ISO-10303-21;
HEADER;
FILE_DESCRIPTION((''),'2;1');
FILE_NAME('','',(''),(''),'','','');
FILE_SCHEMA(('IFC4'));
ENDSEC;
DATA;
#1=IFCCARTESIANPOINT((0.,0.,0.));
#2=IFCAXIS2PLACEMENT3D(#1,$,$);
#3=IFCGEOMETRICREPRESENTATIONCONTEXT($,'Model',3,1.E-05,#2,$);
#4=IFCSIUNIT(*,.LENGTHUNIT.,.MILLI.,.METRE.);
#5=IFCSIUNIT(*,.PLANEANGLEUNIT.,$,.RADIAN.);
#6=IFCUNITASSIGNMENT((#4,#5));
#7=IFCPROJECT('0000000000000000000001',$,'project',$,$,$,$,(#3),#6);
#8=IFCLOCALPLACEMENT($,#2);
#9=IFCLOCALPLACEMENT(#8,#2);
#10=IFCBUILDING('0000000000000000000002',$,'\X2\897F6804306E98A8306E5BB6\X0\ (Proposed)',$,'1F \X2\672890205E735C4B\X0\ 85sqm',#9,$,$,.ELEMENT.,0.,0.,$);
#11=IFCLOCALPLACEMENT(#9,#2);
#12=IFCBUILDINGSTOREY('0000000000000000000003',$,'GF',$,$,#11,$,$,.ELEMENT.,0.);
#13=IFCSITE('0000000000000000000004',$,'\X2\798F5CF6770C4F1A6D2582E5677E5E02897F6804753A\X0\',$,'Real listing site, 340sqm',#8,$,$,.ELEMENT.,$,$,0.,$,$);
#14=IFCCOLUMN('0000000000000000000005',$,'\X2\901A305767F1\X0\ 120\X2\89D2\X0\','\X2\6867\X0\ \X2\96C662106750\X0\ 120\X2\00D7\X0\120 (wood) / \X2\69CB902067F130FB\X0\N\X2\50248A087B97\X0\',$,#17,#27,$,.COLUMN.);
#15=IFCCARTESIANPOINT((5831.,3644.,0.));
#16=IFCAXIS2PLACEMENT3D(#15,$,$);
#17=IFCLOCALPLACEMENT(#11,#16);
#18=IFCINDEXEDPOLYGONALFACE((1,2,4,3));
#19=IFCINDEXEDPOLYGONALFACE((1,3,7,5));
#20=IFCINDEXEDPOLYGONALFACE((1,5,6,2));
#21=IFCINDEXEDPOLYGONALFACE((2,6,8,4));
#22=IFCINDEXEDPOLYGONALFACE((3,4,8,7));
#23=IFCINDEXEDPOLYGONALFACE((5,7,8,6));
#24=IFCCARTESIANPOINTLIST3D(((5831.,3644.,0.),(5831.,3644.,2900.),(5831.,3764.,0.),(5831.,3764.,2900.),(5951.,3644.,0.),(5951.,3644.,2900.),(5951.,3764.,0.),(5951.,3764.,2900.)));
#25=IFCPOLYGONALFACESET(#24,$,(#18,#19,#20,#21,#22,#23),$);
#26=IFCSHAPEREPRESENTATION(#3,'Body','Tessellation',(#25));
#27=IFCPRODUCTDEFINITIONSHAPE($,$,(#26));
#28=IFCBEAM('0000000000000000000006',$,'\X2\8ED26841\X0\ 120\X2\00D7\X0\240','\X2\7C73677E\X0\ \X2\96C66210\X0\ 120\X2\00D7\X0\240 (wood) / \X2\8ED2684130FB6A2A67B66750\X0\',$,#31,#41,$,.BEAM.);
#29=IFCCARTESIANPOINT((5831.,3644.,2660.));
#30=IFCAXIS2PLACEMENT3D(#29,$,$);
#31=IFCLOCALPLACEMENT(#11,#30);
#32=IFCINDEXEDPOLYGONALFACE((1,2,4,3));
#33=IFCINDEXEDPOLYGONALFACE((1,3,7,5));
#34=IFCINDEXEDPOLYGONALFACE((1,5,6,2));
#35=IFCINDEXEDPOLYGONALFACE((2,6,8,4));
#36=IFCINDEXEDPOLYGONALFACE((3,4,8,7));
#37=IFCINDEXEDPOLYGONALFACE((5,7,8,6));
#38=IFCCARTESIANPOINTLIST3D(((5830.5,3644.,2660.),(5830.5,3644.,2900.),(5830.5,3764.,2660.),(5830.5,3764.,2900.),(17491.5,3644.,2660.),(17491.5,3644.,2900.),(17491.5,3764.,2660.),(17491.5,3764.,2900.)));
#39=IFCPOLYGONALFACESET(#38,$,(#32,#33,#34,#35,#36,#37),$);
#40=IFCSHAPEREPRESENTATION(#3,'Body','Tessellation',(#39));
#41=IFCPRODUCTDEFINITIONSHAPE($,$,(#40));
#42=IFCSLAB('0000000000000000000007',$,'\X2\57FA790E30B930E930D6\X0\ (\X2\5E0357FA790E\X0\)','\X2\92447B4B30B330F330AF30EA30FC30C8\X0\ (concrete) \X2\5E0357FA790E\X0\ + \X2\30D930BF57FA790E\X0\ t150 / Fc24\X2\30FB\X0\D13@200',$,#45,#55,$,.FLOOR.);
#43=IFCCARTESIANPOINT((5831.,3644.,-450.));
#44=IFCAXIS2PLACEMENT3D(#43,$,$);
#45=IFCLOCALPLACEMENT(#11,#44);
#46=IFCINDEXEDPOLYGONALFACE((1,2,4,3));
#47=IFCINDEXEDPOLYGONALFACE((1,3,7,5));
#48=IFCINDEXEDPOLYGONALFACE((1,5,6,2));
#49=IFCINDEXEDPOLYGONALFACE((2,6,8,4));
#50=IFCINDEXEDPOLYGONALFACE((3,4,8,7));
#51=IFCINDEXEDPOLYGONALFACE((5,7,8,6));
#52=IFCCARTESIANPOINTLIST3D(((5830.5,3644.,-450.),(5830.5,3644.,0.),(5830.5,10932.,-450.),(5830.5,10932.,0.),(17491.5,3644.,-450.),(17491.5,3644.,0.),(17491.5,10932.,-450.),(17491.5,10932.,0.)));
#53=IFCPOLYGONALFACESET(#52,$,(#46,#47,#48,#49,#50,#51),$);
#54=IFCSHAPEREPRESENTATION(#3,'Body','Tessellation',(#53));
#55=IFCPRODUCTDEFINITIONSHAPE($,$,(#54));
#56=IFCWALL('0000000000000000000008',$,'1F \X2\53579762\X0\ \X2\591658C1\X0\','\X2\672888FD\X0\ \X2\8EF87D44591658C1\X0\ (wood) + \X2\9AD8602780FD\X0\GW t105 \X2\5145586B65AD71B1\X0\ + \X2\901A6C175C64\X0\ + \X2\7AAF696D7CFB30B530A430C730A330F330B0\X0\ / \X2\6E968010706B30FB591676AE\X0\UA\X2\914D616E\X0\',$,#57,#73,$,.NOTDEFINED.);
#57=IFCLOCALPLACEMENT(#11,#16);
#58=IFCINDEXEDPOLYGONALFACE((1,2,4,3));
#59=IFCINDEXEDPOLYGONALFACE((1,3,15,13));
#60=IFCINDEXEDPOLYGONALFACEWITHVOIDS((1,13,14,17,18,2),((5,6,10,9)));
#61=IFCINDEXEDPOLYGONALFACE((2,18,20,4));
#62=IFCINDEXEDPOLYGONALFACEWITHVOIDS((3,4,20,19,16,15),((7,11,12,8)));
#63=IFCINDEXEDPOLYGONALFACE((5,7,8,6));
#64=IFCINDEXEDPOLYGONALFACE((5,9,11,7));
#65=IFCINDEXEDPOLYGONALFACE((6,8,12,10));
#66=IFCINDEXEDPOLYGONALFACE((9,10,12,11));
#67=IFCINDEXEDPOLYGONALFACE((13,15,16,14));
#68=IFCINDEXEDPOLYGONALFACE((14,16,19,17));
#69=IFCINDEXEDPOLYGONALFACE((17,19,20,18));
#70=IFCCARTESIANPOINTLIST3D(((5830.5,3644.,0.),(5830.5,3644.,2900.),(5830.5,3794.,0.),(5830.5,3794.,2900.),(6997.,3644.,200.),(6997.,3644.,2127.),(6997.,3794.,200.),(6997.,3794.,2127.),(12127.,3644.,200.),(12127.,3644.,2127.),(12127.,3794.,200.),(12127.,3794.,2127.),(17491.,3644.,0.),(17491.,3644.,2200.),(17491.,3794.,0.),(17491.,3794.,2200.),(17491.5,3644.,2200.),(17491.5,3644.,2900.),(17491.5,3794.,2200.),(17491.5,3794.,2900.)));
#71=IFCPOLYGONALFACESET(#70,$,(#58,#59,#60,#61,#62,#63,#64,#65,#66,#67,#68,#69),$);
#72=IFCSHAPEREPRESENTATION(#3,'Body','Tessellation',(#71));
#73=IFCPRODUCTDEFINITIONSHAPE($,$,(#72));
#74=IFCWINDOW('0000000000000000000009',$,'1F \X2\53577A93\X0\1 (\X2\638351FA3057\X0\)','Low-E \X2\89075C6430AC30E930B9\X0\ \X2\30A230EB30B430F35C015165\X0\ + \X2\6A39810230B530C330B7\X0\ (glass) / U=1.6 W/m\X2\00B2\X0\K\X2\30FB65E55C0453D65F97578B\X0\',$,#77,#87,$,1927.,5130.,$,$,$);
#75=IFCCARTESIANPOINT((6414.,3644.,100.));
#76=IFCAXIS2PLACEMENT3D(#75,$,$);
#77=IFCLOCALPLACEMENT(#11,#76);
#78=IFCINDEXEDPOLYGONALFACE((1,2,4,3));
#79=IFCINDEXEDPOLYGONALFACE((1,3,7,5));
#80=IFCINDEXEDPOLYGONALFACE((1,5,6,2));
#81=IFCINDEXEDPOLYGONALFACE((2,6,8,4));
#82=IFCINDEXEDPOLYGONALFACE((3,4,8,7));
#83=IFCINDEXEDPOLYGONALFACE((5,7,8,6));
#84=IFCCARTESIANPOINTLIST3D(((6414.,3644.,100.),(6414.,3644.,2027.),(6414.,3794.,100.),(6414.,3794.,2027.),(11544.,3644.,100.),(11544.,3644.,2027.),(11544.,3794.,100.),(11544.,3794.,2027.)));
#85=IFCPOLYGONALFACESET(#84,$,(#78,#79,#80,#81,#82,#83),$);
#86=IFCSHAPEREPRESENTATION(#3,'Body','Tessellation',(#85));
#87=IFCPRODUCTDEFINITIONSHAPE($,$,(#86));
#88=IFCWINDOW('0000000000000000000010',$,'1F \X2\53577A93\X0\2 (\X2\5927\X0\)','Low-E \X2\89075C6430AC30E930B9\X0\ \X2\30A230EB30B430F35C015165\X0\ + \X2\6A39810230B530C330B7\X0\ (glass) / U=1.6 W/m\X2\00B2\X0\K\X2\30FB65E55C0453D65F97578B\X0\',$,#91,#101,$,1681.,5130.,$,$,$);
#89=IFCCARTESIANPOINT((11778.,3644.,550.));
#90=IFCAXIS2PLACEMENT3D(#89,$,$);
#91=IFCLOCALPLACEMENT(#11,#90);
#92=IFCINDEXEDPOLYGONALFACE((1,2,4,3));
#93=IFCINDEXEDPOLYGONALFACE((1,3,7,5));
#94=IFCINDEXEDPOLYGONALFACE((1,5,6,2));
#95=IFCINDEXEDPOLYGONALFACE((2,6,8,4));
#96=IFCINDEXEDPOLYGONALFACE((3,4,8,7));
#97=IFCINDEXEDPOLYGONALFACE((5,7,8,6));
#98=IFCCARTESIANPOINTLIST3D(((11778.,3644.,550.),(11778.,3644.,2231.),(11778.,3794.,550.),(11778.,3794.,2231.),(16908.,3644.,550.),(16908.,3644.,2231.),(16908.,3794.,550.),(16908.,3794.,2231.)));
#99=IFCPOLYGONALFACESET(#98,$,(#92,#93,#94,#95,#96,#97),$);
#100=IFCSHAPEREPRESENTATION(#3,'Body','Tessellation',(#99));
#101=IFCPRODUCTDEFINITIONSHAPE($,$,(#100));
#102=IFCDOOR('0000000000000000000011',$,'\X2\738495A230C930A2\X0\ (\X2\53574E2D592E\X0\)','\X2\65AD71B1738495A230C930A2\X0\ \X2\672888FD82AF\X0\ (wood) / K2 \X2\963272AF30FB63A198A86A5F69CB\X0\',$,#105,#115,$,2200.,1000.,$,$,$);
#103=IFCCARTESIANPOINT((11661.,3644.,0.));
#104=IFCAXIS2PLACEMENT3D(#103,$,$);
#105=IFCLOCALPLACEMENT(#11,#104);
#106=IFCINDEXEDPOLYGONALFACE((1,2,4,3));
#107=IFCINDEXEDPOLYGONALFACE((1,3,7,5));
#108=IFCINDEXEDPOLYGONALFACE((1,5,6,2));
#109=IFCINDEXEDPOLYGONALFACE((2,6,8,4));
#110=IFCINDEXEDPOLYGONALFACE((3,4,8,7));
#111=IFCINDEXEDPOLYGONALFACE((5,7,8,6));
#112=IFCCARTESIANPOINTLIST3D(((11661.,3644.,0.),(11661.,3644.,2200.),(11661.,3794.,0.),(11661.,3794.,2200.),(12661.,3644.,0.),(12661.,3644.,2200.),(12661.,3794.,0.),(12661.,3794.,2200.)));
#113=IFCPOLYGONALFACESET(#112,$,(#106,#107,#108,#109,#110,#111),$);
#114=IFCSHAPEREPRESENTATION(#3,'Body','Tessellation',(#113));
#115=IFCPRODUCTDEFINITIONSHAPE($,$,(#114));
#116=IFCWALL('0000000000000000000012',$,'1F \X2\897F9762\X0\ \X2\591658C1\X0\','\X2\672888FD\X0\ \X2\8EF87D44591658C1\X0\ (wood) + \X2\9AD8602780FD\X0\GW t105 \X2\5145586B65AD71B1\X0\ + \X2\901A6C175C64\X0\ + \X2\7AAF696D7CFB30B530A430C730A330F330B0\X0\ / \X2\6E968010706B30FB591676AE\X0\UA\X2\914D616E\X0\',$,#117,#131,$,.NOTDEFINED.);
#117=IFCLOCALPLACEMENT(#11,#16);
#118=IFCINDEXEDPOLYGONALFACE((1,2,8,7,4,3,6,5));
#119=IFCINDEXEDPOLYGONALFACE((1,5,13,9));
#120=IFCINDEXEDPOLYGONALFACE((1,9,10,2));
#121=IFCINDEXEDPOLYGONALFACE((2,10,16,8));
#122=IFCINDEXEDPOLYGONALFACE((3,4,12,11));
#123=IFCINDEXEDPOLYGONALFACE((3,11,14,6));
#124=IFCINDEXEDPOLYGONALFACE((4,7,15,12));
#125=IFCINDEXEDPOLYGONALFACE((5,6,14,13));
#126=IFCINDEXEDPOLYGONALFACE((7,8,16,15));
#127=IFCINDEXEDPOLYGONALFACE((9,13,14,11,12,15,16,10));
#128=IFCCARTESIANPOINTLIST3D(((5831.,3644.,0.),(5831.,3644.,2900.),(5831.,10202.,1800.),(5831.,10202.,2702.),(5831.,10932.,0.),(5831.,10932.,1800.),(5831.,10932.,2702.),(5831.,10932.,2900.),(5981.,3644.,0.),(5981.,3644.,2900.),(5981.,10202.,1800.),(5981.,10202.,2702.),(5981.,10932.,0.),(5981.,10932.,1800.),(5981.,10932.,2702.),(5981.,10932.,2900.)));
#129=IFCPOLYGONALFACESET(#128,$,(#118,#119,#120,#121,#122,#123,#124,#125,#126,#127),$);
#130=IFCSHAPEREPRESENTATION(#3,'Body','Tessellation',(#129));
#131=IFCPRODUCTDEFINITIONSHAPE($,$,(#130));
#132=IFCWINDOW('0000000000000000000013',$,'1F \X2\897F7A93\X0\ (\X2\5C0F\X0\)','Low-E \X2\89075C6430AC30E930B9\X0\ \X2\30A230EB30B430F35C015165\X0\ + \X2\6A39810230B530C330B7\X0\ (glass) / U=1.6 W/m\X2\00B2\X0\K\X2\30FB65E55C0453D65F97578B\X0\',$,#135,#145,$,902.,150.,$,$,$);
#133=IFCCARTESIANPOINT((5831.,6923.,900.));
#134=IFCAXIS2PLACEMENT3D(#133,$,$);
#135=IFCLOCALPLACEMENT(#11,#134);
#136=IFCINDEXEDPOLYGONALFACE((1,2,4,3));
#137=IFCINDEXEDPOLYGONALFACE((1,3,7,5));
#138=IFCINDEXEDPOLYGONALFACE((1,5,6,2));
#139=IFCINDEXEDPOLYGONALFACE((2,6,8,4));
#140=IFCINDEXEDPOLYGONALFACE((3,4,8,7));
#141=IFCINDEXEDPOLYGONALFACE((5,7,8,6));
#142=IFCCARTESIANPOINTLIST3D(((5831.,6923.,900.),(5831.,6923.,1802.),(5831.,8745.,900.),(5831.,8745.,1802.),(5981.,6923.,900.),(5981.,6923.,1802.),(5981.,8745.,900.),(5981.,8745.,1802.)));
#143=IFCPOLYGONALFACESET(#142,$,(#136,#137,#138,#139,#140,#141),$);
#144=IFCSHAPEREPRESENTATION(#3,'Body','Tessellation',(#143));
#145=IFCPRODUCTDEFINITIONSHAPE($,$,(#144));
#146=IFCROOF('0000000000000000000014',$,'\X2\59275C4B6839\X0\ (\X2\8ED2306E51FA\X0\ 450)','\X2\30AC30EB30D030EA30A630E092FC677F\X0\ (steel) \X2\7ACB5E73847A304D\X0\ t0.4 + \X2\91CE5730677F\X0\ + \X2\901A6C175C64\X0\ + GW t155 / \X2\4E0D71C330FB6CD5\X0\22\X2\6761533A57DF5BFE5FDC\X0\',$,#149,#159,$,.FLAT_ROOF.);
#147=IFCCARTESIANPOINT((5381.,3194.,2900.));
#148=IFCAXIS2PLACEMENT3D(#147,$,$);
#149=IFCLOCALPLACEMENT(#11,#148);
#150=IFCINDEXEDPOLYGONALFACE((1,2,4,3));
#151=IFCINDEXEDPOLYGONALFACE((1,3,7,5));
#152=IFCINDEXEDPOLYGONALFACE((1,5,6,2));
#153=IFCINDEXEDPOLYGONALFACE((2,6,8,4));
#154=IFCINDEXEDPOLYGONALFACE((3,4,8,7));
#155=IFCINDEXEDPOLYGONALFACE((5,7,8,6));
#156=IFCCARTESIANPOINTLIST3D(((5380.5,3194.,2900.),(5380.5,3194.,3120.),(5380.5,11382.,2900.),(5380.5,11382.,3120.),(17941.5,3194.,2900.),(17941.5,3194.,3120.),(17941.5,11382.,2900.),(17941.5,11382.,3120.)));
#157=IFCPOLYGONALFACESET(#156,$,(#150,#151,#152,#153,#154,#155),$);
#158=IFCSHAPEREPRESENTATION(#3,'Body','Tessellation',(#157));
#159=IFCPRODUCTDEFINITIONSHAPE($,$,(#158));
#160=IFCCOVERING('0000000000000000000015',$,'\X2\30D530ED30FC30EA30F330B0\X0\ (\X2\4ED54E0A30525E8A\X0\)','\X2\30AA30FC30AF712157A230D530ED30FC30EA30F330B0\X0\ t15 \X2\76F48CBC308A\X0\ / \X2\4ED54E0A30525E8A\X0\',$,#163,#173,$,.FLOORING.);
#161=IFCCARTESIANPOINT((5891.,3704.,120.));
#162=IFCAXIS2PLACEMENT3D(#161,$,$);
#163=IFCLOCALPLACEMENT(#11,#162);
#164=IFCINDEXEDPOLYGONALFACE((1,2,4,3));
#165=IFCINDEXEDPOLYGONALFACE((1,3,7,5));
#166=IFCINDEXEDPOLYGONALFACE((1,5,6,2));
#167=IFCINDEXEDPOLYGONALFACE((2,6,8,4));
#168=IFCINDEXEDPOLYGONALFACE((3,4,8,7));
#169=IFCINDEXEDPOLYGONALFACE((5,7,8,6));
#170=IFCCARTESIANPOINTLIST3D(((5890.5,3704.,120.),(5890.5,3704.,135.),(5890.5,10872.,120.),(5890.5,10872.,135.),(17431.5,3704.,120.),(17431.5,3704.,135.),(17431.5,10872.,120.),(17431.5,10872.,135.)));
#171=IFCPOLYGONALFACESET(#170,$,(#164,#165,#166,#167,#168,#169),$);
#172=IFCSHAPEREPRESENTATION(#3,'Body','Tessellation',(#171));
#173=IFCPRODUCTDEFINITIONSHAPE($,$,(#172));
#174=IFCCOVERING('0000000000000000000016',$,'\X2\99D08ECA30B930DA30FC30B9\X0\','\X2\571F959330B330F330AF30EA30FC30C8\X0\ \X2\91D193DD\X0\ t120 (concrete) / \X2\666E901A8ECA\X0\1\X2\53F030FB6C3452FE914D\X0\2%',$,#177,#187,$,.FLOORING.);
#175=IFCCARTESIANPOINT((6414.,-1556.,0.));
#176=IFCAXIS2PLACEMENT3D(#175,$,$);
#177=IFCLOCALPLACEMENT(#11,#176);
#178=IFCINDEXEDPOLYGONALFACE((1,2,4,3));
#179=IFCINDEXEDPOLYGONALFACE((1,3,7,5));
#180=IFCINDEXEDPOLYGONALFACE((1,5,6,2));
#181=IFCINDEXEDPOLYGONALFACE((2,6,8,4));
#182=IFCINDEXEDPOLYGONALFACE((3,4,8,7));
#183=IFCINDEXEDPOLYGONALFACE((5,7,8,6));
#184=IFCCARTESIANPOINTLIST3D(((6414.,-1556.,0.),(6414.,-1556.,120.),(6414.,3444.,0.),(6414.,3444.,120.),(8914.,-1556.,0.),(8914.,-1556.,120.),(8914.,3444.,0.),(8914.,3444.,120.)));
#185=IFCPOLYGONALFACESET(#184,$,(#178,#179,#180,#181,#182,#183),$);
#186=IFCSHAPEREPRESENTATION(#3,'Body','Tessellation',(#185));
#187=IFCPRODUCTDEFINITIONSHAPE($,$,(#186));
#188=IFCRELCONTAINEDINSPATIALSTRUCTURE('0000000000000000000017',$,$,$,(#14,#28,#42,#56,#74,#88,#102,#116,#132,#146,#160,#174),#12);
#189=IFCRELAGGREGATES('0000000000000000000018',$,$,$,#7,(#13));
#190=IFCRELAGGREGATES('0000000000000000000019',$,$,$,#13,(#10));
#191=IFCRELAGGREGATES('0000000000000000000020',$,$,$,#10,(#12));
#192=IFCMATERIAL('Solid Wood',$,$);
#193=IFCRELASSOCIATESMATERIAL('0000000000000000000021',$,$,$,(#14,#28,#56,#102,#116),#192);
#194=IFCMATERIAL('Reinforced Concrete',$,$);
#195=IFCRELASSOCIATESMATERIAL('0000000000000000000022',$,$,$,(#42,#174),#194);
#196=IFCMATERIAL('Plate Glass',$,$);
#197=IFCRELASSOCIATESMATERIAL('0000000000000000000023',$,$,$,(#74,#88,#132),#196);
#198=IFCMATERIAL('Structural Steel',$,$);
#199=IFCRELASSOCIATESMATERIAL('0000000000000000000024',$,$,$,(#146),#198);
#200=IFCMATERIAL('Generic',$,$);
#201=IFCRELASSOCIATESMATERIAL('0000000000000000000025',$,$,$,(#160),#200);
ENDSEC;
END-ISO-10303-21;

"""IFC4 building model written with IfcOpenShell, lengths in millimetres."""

from ifc_helpers import new_model, si_unit, frame, frame_2d, origin, place, context, project, spatial, rectangle, extrude, material, element, fill, save


model = new_model("IFC4")

# Units and contexts
model_context = context("Model", 3, precision=1e-05, world=origin())
ifc_project = project(units=[si_unit("LENGTHUNIT", "METRE", prefix="MILLI"), si_unit("PLANEANGLEUNIT", "RADIAN")], contexts=[model_context])

# Site, building, storey
site_placement = place(None, origin())
site = spatial("IfcSite", under=ifc_project, at=site_placement, Name="福島県会津若松市西栄町", ObjectType="Real listing site, 340sqm", CompositionType="ELEMENT", RefElevation=0.0)
building_placement = place(site_placement, origin())
building = spatial("IfcBuilding", under=site, at=building_placement, Name="西栄の風の家 (Proposed)", ObjectType="1F 木造平屋 85sqm", CompositionType="ELEMENT", ElevationOfRefHeight=0.0, ElevationOfTerrain=0.0)
storey_placement = place(building_placement, origin())
storey = spatial("IfcBuildingStorey", under=building, at=storey_placement, Name="GF", CompositionType="ELEMENT", Elevation=0.0)

# Column
ifc_material_1 = material(Name="Solid Wood")
column_1_placement = place(storey_placement, frame((5831.0, 3644.0, 0.0)))
element("IfcColumn", 1, at=column_1_placement, inside=storey, material=ifc_material_1, Name="通し柱 120角", Description="桧 集成材 120×120 (wood) / 構造柱・N値計算", PredefinedType="COLUMN", context=model_context, shape_type="SweptSolid", body=[
    extrude(rectangle(XDim=120.0, YDim=120.0, at=frame_2d((60.0, 60.0))), frame((5831.0, 3644.0, 0.0)), (0.0, 0.0, 1.0), 2900.0),
])

# Beam
beam_1_placement = place(storey_placement, frame((5831.0, 3644.0, 2660.0)))
element("IfcBeam", 2, at=beam_1_placement, inside=storey, material=ifc_material_1, Name="軒桁 120×240", Description="米松 集成 120×240 (wood) / 軒桁・横架材", PredefinedType="BEAM", context=model_context, shape_type="SweptSolid", body=[
    extrude(rectangle(XDim=11661.0, YDim=120.0, at=frame_2d((5830.0, 60.0))), frame((5831.0, 3644.0, 2660.0)), (0.0, 0.0, 1.0), 240.0),
])

# Slab
ifc_material_2 = material(Name="Reinforced Concrete")
slab_1_placement = place(storey_placement, frame((5831.0, 3644.0, -450.0)))
element("IfcSlab", 3, at=slab_1_placement, inside=storey, material=ifc_material_2, Name="基礎スラブ (布基礎)", Description="鉄筋コンクリート (concrete) 布基礎 + ベタ基礎 t150 / Fc24・D13@200", PredefinedType="FLOOR", context=model_context, shape_type="SweptSolid", body=[
    extrude(rectangle(XDim=11661.0, YDim=7288.0, at=frame_2d((5830.0, 3644.0))), frame((5831.0, 3644.0, -450.0)), (0.0, 0.0, 1.0), 450.0),
])

# Wall, openings, windows, door
wall_1_placement = place(storey_placement, frame((5831.0, 3644.0, 0.0)))
wall_1 = element("IfcWall", 4, at=wall_1_placement, inside=storey, material=ifc_material_1, Name="1F 南面 外壁", Description="木製 軸組外壁 (wood) + 高性能GW t105 充填断熱 + 通気層 + 窯業系サイディング / 準耐火・外皮UA配慮", PredefinedType="NOTDEFINED", context=model_context, shape_type="SweptSolid", body=[
    extrude(rectangle(XDim=11661.0, YDim=150.0, at=frame_2d((5830.0, 75.0))), frame((5831.0, 3644.0, 0.0)), (0.0, 0.0, 1.0), 2900.0),
])
opening_1_placement = place(storey_placement, frame((6414.0, 3644.0, 100.0)))
opening_1 = element("IfcOpeningElement", 5, at=opening_1_placement, cuts=wall_1, PredefinedType="NOTDEFINED", context=model_context, shape_type="SweptSolid", body=[
    extrude(rectangle(XDim=5130.0, YDim=150.0, at=frame_2d((2565.0, 75.0))), frame((6414.0, 3644.0, 100.0)), (0.0, 0.0, 1.0), 1927.0),
])
opening_2_placement = place(storey_placement, frame((11778.0, 3644.0, 550.0)))
opening_2 = element("IfcOpeningElement", 6, at=opening_2_placement, cuts=wall_1, PredefinedType="NOTDEFINED", context=model_context, shape_type="SweptSolid", body=[
    extrude(rectangle(XDim=5130.0, YDim=150.0, at=frame_2d((2565.0, 75.0))), frame((11778.0, 3644.0, 550.0)), (0.0, 0.0, 1.0), 1681.0),
])
opening_3_placement = place(storey_placement, frame((11661.0, 3644.0, 0.0)))
opening_3 = element("IfcOpeningElement", 7, at=opening_3_placement, cuts=wall_1, PredefinedType="NOTDEFINED", context=model_context, shape_type="SweptSolid", body=[
    extrude(rectangle(XDim=1000.0, YDim=150.0, at=frame_2d((500.0, 75.0))), frame((11661.0, 3644.0, 0.0)), (0.0, 0.0, 1.0), 2200.0),
])
ifc_material_3 = material(Name="Plate Glass")
window_1_placement = place(storey_placement, frame((6414.0, 3644.0, 100.0)))
window_1 = element("IfcWindow", 8, at=window_1_placement, inside=storey, material=ifc_material_3, Name="1F 南窓1 (掃出し)", Description="Low-E 複層ガラス アルゴン封入 + 樹脂サッシ (glass) / U=1.6 W/m²K・日射取得型", OverallHeight=1927.0, OverallWidth=5130.0, context=model_context, shape_type="SweptSolid", body=[
    extrude(rectangle(XDim=5130.0, YDim=150.0, at=frame_2d((2565.0, 75.0))), frame((6414.0, 3644.0, 100.0)), (0.0, 0.0, 1.0), 1927.0),
])
fill(opening_1, window_1)
window_2_placement = place(storey_placement, frame((11778.0, 3644.0, 550.0)))
window_2 = element("IfcWindow", 9, at=window_2_placement, inside=storey, material=ifc_material_3, Name="1F 南窓2 (大)", Description="Low-E 複層ガラス アルゴン封入 + 樹脂サッシ (glass) / U=1.6 W/m²K・日射取得型", OverallHeight=1681.0, OverallWidth=5130.0, context=model_context, shape_type="SweptSolid", body=[
    extrude(rectangle(XDim=5130.0, YDim=150.0, at=frame_2d((2565.0, 75.0))), frame((11778.0, 3644.0, 550.0)), (0.0, 0.0, 1.0), 1681.0),
])
fill(opening_2, window_2)
door_placement = place(storey_placement, frame((11661.0, 3644.0, 0.0)))
door = element("IfcDoor", 10, at=door_placement, inside=storey, material=ifc_material_1, Name="玄関ドア (南中央)", Description="断熱玄関ドア 木製芯 (wood) / K2 防犯・採風機構", OverallHeight=2200.0, OverallWidth=1000.0, context=model_context, shape_type="SweptSolid", body=[
    extrude(rectangle(XDim=1000.0, YDim=150.0, at=frame_2d((500.0, 75.0))), frame((11661.0, 3644.0, 0.0)), (0.0, 0.0, 1.0), 2200.0),
])
fill(opening_3, door)

# Wall, opening, window
wall_2_placement = place(storey_placement, frame((5831.0, 3644.0, 0.0)))
wall_2 = element("IfcWall", 11, at=wall_2_placement, inside=storey, material=ifc_material_1, Name="1F 西面 外壁", Description="木製 軸組外壁 (wood) + 高性能GW t105 充填断熱 + 通気層 + 窯業系サイディング / 準耐火・外皮UA配慮", PredefinedType="NOTDEFINED", context=model_context, shape_type="SweptSolid", body=[
    extrude(rectangle(XDim=150.0, YDim=7288.0, at=frame_2d((75.0, 3644.0))), frame((5831.0, 3644.0, 0.0)), (0.0, 0.0, 1.0), 2900.0),
])
opening_4_placement = place(storey_placement, frame((5831.0, 6923.0, 900.0)))
opening_4 = element("IfcOpeningElement", 12, at=opening_4_placement, cuts=wall_2, PredefinedType="NOTDEFINED", context=model_context, shape_type="SweptSolid", body=[
    extrude(rectangle(XDim=150.0, YDim=1822.0, at=frame_2d((75.0, 911.0))), frame((5831.0, 6923.0, 900.0)), (0.0, 0.0, 1.0), 902.0),
])
window_3_placement = place(storey_placement, frame((5831.0, 6923.0, 900.0)))
window_3 = element("IfcWindow", 13, at=window_3_placement, inside=storey, material=ifc_material_3, Name="1F 西窓 (小)", Description="Low-E 複層ガラス アルゴン封入 + 樹脂サッシ (glass) / U=1.6 W/m²K・日射取得型", OverallHeight=902.0, OverallWidth=150.0, context=model_context, shape_type="SweptSolid", body=[
    extrude(rectangle(XDim=150.0, YDim=1822.0, at=frame_2d((75.0, 911.0))), frame((5831.0, 6923.0, 900.0)), (0.0, 0.0, 1.0), 902.0),
])
fill(opening_4, window_3)

# Roof
ifc_material_4 = material(Name="Structural Steel")
roof_placement = place(storey_placement, frame((5381.0, 3194.0, 2900.0)))
element("IfcRoof", 14, at=roof_placement, inside=storey, material=ifc_material_4, Name="大屋根 (軒の出 450)", Description="ガルバリウム鋼板 (steel) 立平葺き t0.4 + 野地板 + 通気層 + GW t155 / 不燃・法22条区域対応", PredefinedType="FLAT_ROOF", context=model_context, shape_type="SweptSolid", body=[
    extrude(rectangle(XDim=12561.0, YDim=8188.0, at=frame_2d((6280.0, 4094.0))), frame((5381.0, 3194.0, 2900.0)), (0.0, 0.0, 1.0), 220.0),
])

# Coverings
ifc_material_5 = material(Name="Generic")
covering_1_placement = place(storey_placement, frame((5891.0, 3704.0, 120.0)))
element("IfcCovering", 15, at=covering_1_placement, inside=storey, material=ifc_material_5, Name="フローリング (仕上げ床)", Description="オーク無垢フローリング t15 直貼り / 仕上げ床", PredefinedType="FLOORING", context=model_context, shape_type="SweptSolid", body=[
    extrude(rectangle(XDim=11541.0, YDim=7168.0, at=frame_2d((5770.0, 3584.0))), frame((5891.0, 3704.0, 120.0)), (0.0, 0.0, 1.0), 15.0),
])
covering_2_placement = place(storey_placement, frame((6414.0, -1556.0, 0.0)))
element("IfcCovering", 16, at=covering_2_placement, inside=storey, material=ifc_material_2, Name="駐車スペース", Description="土間コンクリート 金鏝 t120 (concrete) / 普通車1台・水勾配2%", PredefinedType="FLOORING", context=model_context, shape_type="SweptSolid", body=[
    extrude(rectangle(XDim=2500.0, YDim=5000.0, at=frame_2d((1250.0, 2500.0))), frame((6414.0, -1556.0, 0.0)), (0.0, 0.0, 1.0), 120.0),
])

save(model, "model.ifc")
